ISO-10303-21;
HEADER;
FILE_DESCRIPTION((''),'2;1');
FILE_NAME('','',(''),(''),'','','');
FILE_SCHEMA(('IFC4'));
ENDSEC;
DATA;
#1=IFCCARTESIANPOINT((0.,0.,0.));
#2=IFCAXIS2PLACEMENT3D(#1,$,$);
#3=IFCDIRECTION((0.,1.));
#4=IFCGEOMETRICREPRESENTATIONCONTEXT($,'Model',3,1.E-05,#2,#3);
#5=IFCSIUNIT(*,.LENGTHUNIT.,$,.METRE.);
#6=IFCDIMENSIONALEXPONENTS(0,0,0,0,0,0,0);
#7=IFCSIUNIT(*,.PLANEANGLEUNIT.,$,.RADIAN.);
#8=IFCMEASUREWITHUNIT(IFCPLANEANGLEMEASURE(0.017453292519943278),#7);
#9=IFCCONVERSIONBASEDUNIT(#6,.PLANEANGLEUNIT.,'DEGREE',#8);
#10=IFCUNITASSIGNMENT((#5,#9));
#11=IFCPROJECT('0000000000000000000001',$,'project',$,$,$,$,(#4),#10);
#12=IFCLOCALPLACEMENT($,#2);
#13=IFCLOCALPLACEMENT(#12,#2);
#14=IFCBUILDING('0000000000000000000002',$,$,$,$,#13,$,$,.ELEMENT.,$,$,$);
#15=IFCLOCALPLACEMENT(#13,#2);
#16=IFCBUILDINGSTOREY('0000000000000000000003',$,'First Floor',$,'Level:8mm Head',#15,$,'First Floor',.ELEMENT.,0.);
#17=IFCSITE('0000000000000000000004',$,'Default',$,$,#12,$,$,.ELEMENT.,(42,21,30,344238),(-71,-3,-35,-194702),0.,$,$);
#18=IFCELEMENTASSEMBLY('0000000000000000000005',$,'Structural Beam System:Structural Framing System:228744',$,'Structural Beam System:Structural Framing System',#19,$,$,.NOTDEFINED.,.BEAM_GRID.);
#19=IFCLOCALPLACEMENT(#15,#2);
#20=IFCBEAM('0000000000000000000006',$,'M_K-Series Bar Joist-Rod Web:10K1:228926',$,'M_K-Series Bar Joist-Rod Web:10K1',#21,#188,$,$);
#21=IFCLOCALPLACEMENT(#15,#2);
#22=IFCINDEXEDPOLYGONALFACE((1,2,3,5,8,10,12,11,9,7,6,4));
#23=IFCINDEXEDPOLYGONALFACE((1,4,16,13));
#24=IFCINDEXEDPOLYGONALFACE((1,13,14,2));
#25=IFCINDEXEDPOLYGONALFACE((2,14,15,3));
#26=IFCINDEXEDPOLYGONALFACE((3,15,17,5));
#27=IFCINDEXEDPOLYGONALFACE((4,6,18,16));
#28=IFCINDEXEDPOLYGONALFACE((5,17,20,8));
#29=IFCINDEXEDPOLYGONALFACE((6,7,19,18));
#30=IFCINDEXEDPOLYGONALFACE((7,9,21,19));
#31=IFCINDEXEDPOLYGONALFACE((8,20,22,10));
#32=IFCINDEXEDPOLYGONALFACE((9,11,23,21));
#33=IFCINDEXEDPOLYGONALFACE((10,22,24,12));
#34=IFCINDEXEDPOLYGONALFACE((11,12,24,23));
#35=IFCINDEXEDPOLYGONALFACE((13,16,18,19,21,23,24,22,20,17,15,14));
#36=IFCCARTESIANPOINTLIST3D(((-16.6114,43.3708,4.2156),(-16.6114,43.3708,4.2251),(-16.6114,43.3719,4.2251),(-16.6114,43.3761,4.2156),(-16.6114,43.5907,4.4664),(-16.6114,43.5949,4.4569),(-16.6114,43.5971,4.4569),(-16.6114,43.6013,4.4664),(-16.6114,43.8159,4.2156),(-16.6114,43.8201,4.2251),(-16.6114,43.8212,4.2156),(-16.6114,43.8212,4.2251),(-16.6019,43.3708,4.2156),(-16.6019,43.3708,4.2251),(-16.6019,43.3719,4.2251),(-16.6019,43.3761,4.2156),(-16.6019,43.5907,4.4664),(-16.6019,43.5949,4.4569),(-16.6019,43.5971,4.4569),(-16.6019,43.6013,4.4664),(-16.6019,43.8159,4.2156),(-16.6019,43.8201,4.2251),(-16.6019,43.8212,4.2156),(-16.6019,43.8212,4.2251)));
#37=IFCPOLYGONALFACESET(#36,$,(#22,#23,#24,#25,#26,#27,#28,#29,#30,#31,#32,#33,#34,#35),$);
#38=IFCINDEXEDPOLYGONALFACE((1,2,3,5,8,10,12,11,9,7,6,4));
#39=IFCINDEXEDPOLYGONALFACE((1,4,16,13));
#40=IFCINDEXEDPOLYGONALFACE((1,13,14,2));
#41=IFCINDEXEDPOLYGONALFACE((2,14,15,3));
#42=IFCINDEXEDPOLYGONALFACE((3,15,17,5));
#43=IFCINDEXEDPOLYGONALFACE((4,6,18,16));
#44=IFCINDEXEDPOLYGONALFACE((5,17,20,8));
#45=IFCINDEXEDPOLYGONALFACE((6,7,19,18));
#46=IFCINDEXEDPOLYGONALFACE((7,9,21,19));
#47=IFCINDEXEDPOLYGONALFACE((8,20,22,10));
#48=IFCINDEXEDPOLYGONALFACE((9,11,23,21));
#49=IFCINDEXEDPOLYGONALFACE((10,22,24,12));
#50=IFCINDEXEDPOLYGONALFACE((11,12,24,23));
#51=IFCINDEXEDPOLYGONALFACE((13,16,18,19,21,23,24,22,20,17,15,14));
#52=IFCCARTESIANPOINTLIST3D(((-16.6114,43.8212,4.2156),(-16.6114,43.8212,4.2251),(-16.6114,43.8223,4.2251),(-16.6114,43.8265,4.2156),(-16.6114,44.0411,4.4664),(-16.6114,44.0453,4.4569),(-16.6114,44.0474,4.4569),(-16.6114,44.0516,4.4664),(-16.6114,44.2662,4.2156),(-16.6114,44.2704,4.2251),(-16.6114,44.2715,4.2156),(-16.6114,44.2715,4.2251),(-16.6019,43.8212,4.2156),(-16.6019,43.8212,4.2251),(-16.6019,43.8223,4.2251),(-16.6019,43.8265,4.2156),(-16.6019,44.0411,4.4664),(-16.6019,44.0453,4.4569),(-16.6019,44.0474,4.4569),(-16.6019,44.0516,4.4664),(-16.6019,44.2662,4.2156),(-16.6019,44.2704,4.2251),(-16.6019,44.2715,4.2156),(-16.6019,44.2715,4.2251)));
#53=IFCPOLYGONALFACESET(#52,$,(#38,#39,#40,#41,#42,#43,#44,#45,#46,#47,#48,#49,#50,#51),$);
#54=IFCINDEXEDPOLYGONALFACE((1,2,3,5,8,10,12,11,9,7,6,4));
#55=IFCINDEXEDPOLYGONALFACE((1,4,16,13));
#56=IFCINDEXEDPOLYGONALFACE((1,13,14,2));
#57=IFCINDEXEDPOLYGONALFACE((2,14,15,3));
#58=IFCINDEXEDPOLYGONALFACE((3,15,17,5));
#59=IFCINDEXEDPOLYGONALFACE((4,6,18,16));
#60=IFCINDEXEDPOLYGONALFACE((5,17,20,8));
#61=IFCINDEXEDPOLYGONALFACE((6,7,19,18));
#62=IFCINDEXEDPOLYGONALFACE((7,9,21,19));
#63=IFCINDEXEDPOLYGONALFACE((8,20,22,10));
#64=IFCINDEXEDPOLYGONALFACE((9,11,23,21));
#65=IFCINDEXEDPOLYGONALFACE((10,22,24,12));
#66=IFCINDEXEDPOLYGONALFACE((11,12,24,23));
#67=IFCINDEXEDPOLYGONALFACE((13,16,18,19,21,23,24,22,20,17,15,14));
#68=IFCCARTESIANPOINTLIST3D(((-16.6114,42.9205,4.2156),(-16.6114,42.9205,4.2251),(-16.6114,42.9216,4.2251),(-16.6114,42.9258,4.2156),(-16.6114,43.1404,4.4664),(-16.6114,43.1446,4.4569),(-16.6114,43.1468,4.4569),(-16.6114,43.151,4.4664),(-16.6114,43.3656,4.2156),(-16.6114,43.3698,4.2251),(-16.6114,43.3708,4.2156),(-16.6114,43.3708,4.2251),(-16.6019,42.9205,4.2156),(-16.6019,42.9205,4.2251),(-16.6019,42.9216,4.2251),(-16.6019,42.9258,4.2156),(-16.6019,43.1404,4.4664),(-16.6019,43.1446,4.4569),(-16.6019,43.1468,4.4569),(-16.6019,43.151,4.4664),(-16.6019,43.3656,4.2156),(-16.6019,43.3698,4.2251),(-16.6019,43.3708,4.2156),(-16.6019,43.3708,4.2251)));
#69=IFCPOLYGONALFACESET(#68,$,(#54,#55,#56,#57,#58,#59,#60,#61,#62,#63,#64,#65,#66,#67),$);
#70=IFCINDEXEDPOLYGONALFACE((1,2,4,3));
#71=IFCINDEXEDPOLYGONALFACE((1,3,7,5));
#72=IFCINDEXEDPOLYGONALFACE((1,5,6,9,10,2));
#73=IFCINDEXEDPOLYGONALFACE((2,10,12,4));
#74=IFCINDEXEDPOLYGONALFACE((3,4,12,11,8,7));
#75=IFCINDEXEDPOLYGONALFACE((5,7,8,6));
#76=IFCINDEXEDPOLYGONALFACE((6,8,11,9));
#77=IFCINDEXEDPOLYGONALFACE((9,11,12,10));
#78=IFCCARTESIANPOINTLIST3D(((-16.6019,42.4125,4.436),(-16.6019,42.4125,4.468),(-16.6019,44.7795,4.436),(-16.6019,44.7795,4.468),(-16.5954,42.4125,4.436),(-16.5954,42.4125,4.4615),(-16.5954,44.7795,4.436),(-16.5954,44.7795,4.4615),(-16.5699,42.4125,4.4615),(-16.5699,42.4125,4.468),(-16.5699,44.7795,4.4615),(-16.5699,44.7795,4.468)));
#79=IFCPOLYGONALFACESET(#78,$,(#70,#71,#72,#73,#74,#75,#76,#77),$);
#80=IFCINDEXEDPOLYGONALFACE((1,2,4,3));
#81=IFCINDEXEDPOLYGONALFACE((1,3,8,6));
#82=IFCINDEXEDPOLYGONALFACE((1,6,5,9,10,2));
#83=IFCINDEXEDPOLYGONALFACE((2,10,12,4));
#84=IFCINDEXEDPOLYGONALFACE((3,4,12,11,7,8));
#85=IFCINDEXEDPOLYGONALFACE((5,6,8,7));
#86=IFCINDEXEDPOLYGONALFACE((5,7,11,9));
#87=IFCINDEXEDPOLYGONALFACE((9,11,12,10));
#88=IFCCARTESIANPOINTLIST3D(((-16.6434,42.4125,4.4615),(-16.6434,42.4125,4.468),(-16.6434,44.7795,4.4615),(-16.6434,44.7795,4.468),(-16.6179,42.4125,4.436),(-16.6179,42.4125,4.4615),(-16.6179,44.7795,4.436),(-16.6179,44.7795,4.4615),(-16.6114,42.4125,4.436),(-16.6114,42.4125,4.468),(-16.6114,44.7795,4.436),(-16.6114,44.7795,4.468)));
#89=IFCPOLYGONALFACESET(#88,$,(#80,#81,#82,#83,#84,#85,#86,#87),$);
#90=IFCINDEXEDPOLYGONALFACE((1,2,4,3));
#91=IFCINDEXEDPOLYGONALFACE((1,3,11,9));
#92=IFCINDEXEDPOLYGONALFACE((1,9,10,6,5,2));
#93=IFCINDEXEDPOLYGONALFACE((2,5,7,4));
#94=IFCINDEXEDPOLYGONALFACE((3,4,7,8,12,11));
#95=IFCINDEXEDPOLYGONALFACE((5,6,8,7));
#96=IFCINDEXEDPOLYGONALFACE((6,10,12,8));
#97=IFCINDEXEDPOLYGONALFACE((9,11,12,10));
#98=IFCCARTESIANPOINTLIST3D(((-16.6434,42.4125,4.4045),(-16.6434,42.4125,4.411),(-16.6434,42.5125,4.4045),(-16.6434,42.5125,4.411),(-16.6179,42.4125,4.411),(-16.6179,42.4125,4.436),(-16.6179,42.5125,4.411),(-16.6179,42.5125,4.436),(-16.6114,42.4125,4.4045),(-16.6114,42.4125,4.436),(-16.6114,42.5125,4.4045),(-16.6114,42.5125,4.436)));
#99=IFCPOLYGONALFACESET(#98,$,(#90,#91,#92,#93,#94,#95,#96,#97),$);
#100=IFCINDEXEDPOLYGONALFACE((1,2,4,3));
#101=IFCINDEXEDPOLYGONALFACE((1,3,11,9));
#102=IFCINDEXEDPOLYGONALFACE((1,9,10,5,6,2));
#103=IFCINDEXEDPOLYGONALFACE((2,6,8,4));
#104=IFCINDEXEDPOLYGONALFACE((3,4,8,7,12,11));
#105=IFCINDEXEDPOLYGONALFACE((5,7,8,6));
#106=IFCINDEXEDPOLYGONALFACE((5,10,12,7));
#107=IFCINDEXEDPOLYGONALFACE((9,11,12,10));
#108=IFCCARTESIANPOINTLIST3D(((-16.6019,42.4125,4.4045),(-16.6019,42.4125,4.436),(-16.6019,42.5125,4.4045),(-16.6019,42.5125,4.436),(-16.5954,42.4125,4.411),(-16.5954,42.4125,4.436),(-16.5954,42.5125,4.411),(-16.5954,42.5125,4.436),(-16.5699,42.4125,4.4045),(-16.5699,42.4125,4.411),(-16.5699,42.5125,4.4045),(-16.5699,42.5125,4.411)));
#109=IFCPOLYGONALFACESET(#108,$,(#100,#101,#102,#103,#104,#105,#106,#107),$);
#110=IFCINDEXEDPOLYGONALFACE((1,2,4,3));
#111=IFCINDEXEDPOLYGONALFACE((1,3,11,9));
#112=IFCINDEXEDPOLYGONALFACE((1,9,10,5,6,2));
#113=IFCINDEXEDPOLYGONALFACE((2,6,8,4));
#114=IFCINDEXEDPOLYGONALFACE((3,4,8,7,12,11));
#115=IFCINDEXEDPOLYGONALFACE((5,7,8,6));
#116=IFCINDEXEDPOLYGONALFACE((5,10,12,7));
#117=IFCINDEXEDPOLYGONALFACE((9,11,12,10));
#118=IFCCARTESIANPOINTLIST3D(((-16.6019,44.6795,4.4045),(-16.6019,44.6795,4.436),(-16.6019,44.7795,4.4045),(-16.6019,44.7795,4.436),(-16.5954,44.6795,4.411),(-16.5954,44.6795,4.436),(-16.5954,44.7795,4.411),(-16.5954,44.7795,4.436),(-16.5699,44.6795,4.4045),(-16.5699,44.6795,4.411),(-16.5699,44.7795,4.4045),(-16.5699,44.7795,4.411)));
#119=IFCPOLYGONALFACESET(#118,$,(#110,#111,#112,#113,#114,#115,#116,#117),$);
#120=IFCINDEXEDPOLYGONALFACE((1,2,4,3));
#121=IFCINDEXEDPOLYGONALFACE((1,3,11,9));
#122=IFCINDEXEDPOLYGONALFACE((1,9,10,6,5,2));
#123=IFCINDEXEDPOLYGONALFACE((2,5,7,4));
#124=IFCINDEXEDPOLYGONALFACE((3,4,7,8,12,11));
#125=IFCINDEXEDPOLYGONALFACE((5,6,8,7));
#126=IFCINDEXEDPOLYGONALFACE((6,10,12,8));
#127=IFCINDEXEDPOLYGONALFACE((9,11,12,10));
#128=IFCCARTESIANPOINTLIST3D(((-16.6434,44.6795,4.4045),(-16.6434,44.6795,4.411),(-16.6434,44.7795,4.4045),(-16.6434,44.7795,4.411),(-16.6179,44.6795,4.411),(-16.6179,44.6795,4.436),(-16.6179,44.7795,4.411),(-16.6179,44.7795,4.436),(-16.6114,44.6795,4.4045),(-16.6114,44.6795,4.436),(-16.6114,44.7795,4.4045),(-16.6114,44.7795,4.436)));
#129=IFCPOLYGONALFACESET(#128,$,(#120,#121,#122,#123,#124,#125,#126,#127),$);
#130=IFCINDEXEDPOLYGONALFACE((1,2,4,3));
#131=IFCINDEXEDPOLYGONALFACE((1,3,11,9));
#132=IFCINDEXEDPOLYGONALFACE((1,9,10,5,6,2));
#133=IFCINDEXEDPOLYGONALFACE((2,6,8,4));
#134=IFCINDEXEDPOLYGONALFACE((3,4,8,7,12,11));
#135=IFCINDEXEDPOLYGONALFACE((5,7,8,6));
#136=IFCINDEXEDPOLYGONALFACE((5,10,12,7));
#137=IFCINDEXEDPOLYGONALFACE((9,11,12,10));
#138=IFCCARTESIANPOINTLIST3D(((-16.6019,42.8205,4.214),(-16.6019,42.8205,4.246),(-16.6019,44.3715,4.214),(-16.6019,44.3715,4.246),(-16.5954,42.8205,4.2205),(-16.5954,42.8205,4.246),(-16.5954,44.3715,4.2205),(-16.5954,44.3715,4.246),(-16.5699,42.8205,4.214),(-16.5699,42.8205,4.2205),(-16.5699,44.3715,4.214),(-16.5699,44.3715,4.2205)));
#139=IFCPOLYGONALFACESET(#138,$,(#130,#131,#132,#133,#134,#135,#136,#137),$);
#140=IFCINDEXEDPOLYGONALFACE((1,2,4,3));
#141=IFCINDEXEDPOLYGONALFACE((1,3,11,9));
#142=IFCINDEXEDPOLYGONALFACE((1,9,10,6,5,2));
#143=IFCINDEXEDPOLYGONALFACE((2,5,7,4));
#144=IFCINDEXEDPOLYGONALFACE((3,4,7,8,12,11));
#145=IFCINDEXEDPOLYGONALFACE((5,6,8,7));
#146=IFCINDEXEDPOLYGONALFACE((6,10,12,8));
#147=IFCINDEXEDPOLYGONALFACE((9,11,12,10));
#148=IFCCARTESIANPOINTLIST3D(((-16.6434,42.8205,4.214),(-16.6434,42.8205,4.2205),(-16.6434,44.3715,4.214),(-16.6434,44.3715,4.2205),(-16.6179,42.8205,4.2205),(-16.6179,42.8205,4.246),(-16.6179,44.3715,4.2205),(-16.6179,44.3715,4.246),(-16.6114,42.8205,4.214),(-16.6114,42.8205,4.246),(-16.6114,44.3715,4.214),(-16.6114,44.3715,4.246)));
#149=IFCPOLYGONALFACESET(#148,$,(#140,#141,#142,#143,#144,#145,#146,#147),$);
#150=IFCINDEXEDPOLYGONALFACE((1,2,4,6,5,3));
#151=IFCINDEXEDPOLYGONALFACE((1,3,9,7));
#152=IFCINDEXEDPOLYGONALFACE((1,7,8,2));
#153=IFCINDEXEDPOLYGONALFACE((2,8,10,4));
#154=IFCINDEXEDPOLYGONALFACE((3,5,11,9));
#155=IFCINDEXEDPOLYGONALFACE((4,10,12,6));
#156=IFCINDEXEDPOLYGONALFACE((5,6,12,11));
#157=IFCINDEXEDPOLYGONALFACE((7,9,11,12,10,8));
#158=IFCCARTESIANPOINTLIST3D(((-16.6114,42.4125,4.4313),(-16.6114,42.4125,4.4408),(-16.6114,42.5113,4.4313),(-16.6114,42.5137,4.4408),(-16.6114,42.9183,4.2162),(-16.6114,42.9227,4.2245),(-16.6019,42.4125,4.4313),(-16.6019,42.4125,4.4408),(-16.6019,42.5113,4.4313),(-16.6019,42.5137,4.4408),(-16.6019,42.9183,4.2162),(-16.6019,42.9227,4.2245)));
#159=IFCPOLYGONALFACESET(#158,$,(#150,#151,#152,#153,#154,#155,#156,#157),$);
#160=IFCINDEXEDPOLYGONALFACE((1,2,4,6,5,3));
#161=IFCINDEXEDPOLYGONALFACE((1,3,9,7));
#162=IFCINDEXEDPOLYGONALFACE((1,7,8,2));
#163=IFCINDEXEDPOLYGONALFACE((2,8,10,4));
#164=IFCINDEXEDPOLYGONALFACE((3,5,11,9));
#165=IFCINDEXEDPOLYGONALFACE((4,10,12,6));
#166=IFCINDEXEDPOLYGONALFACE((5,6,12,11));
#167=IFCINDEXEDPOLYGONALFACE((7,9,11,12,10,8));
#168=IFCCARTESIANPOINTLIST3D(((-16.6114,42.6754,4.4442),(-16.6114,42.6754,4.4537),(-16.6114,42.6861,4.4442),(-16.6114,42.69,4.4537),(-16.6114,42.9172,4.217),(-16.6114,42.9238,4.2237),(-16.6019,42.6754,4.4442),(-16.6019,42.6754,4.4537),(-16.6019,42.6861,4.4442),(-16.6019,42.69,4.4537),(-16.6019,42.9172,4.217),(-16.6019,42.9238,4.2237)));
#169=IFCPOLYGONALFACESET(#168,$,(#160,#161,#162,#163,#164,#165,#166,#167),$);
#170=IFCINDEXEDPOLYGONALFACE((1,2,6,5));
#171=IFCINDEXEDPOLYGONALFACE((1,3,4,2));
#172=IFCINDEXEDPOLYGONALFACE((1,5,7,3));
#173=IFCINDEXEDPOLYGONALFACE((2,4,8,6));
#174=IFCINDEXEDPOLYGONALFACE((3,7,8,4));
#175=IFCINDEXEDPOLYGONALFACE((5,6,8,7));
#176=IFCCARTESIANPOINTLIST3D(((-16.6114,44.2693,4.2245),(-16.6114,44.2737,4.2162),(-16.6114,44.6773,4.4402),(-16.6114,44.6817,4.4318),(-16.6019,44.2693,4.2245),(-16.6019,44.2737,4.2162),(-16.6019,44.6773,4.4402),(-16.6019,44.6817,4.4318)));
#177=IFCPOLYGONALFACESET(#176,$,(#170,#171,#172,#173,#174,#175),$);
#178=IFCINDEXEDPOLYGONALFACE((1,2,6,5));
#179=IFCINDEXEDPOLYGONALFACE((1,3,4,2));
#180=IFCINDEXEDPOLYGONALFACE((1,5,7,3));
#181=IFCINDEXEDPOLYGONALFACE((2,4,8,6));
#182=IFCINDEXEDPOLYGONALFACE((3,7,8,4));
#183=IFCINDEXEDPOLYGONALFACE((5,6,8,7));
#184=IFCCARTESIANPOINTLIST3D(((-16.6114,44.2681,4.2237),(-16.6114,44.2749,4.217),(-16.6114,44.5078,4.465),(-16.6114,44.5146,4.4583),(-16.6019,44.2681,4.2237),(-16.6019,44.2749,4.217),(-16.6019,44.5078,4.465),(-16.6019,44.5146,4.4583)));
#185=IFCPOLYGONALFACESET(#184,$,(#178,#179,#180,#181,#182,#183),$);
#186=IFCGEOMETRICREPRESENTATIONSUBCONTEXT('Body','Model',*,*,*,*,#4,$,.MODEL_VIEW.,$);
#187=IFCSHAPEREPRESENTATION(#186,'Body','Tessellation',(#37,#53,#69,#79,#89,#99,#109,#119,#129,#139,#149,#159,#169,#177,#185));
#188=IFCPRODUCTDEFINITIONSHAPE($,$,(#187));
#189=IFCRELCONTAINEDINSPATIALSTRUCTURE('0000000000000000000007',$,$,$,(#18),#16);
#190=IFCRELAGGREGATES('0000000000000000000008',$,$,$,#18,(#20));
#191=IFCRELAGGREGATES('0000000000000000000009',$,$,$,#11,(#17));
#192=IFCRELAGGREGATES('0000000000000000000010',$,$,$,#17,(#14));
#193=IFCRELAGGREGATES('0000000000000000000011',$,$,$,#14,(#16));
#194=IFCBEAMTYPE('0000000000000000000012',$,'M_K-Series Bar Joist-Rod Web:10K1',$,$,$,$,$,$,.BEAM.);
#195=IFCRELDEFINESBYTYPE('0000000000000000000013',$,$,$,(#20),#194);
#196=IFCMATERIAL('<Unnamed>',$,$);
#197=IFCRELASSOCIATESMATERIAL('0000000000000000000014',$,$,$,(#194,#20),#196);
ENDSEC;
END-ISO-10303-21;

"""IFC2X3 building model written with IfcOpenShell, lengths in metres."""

from ifc_helpers import new_model, entity, si_unit, converted_unit, direction, frame, frame_2d, origin, place, context, subcontext, project, spatial, polyline, rectangle, outline, extrude, source, transform, mapped, material, type_object, type_shapes, element, aggregate, save


model = new_model("IFC2X3")

# Units and contexts
model_context = context("Model", 3, precision=1e-05, world=origin(), true_north=direction((0.0, 1.0)))
body_context = subcontext(model_context, "Body", "Model", "MODEL_VIEW")
ifc_project = project(units=[si_unit("LENGTHUNIT", "METRE"), converted_unit("PLANEANGLEUNIT", "DEGREE", entity("IfcPlaneAngleMeasure", 0.017453292519943278), si_unit("PLANEANGLEUNIT", "RADIAN"), dimensions=[0, 0, 0, 0, 0, 0, 0])], contexts=[model_context])

# Site, building, storey
site_placement = place(None, origin())
site = spatial("IfcSite", under=ifc_project, at=site_placement, Name="Default", CompositionType="ELEMENT", RefLatitude=(42, 21, 30, 344238), RefLongitude=(-71, -3, -35, -194702), RefElevation=0.0)
building_placement = place(site_placement, origin())
building = spatial("IfcBuilding", under=site, at=building_placement, CompositionType="ELEMENT")
storey_placement = place(building_placement, origin())
storey = spatial("IfcBuildingStorey", under=building, at=storey_placement, Name="First Floor", ObjectType="Level:8mm Head", LongName="First Floor", CompositionType="ELEMENT", Elevation=0.0)

# Shared definitions
ifc_material_1 = material(Name="<Unnamed>")

# Element assembly, beam
assembly_1_placement = place(storey_placement, origin())
assembly_1 = element("IfcElementAssembly", 1, at=assembly_1_placement, inside=storey, Name="Structural Beam System:Structural Framing System:228744", ObjectType="Structural Beam System:Structural Framing System", AssemblyPlace="NOTDEFINED", PredefinedType="BEAM_GRID")
beam_type_1 = type_object("IfcBeamType", Name="M_K-Series Bar Joist-Rod Web:10K1", PredefinedType="BEAM", material=ifc_material_1)
shared_shape_1 = source(origin(), body_context, "Body", "SweptSolid", [
    extrude(outline(polyline([(-0.2252, -0.0757), (-0.2252, -0.0852), (-0.2199, -0.0852), (-0.0011, 0.1561), (0.0011, 0.1561), (0.2199, -0.0852), (0.2252, -0.0852), (0.2252, -0.0757), (0.2241, -0.0757), (0.0053, 0.1656), (-0.0053, 0.1656), (-0.2241, -0.0757), (-0.2252, -0.0757)])), frame((0.0, -0.0047, -0.0402), z_axis=(0.0, -1.0, 0.0), x_axis=(1.0, 0.0, 0.0)), (0.0, 0.0, -1.0), 0.0095),
    extrude(outline(polyline([(-0.2252, -0.0757), (-0.2252, -0.0852), (-0.2199, -0.0852), (-0.0011, 0.1561), (0.0011, 0.1561), (0.2199, -0.0852), (0.2252, -0.0852), (0.2252, -0.0757), (0.2241, -0.0757), (0.0053, 0.1656), (-0.0053, 0.1656), (-0.2241, -0.0757), (-0.2252, -0.0757)])), frame((0.4503, -0.0047, -0.0402), z_axis=(0.0, -1.0, 0.0), x_axis=(1.0, 0.0, 0.0)), (0.0, 0.0, -1.0), 0.0095),
    extrude(outline(polyline([(-0.2252, -0.0757), (-0.2252, -0.0852), (-0.2199, -0.0852), (-0.0011, 0.1561), (0.0011, 0.1561), (0.2199, -0.0852), (0.2252, -0.0852), (0.2252, -0.0757), (0.2241, -0.0757), (0.0053, 0.1656), (-0.0053, 0.1656), (-0.2241, -0.0757), (-0.2252, -0.0757)])), frame((-0.4503, -0.0047, -0.0402), z_axis=(0.0, -1.0, 0.0), x_axis=(1.0, 0.0, 0.0)), (0.0, 0.0, -1.0), 0.0095),
    extrude(outline(polyline([(-0.0128, -0.0128), (0.0192, -0.0128), (0.0192, -0.0063), (-0.0063, -0.0063), (-0.0063, 0.0192), (-0.0128, 0.0192), (-0.0128, -0.0128)])), frame((-1.1835, -0.0176, 0.1142), z_axis=(1.0, 0.0, 0.0), x_axis=(0.0, -1.0, 0.0)), (0.0, 0.0, 1.0), 2.367),
    extrude(outline(polyline([(-0.0128, -0.0128), (0.0192, -0.0128), (0.0192, -0.0063), (-0.0063, -0.0063), (-0.0063, 0.0192), (-0.0128, 0.0192), (-0.0128, -0.0128)])), frame((-1.1835, 0.0176, 0.1142), z_axis=(1.0, 0.0, 0.0), x_axis=(0.0, 0.0, -1.0)), (0.0, 0.0, 1.0), 2.367),
    extrude(outline(polyline([(-0.0127, -0.0192), (-0.0062, -0.0192), (-0.0062, 0.0063), (0.0188, 0.0063), (0.0188, 0.0128), (-0.0127, 0.0128), (-0.0127, -0.0192)])), frame((-1.1835, 0.0176, 0.0762), z_axis=(1.0, 0.0, 0.0), x_axis=(0.0, 0.0, 1.0)), (0.0, 0.0, 1.0), 0.1),
    extrude(outline(polyline([(-0.0127, -0.0128), (0.0188, -0.0128), (0.0188, -0.0063), (-0.0062, -0.0063), (-0.0062, 0.0192), (-0.0127, 0.0192), (-0.0127, -0.0128)])), frame((-1.1835, -0.0176, 0.0762), z_axis=(1.0, 0.0, 0.0), x_axis=(0.0, 0.0, 1.0)), (0.0, 0.0, 1.0), 0.1),
    extrude(outline(polyline([(-0.0127, -0.0128), (0.0188, -0.0128), (0.0188, -0.0063), (-0.0062, -0.0063), (-0.0062, 0.0192), (-0.0127, 0.0192), (-0.0127, -0.0128)])), frame((1.0835, -0.0176, 0.0762), z_axis=(1.0, 0.0, 0.0), x_axis=(0.0, 0.0, 1.0)), (0.0, 0.0, 1.0), 0.1),
    extrude(outline(polyline([(-0.0128, -0.0127), (0.0192, -0.0127), (0.0192, -0.0062), (-0.0063, -0.0062), (-0.0063, 0.0188), (-0.0128, 0.0188), (-0.0128, -0.0127)])), frame((1.0835, 0.0176, 0.0762), z_axis=(1.0, 0.0, 0.0), x_axis=(0.0, 1.0, 0.0)), (0.0, 0.0, 1.0), 0.1),
    extrude(outline(polyline([(-0.0128, -0.0128), (0.0192, -0.0128), (0.0192, -0.0063), (-0.0063, -0.0063), (-0.0063, 0.0192), (-0.0128, 0.0192), (-0.0128, -0.0128)])), frame((-0.7755, -0.0176, -0.1142), z_axis=(1.0, 0.0, 0.0), x_axis=(0.0, 0.0, 1.0)), (0.0, 0.0, 1.0), 1.551),
    extrude(outline(polyline([(-0.0128, -0.0128), (0.0192, -0.0128), (0.0192, -0.0063), (-0.0063, -0.0063), (-0.0063, 0.0192), (-0.0128, 0.0192), (-0.0128, -0.0128)])), frame((-0.7755, 0.0176, -0.1142), z_axis=(1.0, 0.0, 0.0), x_axis=(0.0, 1.0, 0.0)), (0.0, 0.0, 1.0), 1.551),
    extrude(outline(polyline([(-0.3371, -0.0108), (-0.3371, -0.0203), (0.1255, -0.0203), (0.215, 0.027), (0.2105, 0.0354), (0.1232, -0.0108), (-0.3371, -0.0108)])), frame((-0.9808, -0.0048, 0.0231), z_axis=(0.0, -1.0, 0.0), x_axis=(-0.884101, 0.0, 0.467295)), (0.0, 0.0, -1.0), 0.0095),
    extrude(outline(polyline([(-0.0859, -0.0809), (-0.0713, -0.0809), (0.1625, 0.149), (0.1559, 0.1558), (-0.0752, -0.0714), (-0.0859, -0.0714), (-0.0859, -0.0809)])), frame((-0.8347, -0.0047, 0.0318), z_axis=(0.0, 1.0, 0.0), x_axis=(1.0, 0.0, 0.0)), (0.0, 0.0, 1.0), 0.0095),
    extrude(rectangle(XDim=0.0095, YDim=0.0095, at=frame_2d((0.0, 0.0), x_axis=(0.0, 1.0))), frame((0.6755, 0.0, -0.1206), z_axis=(0.884101, 0.0, 0.467295), x_axis=(0.0, 1.0, 0.0)), (0.0, 0.0, 1.0), 0.4615),
    extrude(rectangle(XDim=0.3401, YDim=0.0095, at=frame_2d((0.0, 0.0), x_axis=(1.0, 0.0))), frame((0.7953, -0.0047, 0.0), z_axis=(0.0, 1.0, 0.0), x_axis=(-0.704723, 0.0, -0.709483)), (0.0, 0.0, 1.0), 0.0095),
])
type_shapes(beam_type_1, [shared_shape_1])
beam_1_placement = place(assembly_1_placement, frame((-16.6067, 43.596, 4.341), z_axis=(0.0, 0.0, 1.0), x_axis=(0.0, 1.0, 0.0)))
beam_1 = element("IfcBeam", 2, at=beam_1_placement, type_object=beam_type_1, material=ifc_material_1, Name="M_K-Series Bar Joist-Rod Web:10K1:228926", ObjectType="M_K-Series Bar Joist-Rod Web:10K1", context=body_context, shape_type="MappedRepresentation", body=[
    mapped(shared_shape_1, transform((0.0, 0.0, 0.0), scale=1.0)),
])
aggregate(assembly_1, [beam_1])

save(model, "model.ifc")
